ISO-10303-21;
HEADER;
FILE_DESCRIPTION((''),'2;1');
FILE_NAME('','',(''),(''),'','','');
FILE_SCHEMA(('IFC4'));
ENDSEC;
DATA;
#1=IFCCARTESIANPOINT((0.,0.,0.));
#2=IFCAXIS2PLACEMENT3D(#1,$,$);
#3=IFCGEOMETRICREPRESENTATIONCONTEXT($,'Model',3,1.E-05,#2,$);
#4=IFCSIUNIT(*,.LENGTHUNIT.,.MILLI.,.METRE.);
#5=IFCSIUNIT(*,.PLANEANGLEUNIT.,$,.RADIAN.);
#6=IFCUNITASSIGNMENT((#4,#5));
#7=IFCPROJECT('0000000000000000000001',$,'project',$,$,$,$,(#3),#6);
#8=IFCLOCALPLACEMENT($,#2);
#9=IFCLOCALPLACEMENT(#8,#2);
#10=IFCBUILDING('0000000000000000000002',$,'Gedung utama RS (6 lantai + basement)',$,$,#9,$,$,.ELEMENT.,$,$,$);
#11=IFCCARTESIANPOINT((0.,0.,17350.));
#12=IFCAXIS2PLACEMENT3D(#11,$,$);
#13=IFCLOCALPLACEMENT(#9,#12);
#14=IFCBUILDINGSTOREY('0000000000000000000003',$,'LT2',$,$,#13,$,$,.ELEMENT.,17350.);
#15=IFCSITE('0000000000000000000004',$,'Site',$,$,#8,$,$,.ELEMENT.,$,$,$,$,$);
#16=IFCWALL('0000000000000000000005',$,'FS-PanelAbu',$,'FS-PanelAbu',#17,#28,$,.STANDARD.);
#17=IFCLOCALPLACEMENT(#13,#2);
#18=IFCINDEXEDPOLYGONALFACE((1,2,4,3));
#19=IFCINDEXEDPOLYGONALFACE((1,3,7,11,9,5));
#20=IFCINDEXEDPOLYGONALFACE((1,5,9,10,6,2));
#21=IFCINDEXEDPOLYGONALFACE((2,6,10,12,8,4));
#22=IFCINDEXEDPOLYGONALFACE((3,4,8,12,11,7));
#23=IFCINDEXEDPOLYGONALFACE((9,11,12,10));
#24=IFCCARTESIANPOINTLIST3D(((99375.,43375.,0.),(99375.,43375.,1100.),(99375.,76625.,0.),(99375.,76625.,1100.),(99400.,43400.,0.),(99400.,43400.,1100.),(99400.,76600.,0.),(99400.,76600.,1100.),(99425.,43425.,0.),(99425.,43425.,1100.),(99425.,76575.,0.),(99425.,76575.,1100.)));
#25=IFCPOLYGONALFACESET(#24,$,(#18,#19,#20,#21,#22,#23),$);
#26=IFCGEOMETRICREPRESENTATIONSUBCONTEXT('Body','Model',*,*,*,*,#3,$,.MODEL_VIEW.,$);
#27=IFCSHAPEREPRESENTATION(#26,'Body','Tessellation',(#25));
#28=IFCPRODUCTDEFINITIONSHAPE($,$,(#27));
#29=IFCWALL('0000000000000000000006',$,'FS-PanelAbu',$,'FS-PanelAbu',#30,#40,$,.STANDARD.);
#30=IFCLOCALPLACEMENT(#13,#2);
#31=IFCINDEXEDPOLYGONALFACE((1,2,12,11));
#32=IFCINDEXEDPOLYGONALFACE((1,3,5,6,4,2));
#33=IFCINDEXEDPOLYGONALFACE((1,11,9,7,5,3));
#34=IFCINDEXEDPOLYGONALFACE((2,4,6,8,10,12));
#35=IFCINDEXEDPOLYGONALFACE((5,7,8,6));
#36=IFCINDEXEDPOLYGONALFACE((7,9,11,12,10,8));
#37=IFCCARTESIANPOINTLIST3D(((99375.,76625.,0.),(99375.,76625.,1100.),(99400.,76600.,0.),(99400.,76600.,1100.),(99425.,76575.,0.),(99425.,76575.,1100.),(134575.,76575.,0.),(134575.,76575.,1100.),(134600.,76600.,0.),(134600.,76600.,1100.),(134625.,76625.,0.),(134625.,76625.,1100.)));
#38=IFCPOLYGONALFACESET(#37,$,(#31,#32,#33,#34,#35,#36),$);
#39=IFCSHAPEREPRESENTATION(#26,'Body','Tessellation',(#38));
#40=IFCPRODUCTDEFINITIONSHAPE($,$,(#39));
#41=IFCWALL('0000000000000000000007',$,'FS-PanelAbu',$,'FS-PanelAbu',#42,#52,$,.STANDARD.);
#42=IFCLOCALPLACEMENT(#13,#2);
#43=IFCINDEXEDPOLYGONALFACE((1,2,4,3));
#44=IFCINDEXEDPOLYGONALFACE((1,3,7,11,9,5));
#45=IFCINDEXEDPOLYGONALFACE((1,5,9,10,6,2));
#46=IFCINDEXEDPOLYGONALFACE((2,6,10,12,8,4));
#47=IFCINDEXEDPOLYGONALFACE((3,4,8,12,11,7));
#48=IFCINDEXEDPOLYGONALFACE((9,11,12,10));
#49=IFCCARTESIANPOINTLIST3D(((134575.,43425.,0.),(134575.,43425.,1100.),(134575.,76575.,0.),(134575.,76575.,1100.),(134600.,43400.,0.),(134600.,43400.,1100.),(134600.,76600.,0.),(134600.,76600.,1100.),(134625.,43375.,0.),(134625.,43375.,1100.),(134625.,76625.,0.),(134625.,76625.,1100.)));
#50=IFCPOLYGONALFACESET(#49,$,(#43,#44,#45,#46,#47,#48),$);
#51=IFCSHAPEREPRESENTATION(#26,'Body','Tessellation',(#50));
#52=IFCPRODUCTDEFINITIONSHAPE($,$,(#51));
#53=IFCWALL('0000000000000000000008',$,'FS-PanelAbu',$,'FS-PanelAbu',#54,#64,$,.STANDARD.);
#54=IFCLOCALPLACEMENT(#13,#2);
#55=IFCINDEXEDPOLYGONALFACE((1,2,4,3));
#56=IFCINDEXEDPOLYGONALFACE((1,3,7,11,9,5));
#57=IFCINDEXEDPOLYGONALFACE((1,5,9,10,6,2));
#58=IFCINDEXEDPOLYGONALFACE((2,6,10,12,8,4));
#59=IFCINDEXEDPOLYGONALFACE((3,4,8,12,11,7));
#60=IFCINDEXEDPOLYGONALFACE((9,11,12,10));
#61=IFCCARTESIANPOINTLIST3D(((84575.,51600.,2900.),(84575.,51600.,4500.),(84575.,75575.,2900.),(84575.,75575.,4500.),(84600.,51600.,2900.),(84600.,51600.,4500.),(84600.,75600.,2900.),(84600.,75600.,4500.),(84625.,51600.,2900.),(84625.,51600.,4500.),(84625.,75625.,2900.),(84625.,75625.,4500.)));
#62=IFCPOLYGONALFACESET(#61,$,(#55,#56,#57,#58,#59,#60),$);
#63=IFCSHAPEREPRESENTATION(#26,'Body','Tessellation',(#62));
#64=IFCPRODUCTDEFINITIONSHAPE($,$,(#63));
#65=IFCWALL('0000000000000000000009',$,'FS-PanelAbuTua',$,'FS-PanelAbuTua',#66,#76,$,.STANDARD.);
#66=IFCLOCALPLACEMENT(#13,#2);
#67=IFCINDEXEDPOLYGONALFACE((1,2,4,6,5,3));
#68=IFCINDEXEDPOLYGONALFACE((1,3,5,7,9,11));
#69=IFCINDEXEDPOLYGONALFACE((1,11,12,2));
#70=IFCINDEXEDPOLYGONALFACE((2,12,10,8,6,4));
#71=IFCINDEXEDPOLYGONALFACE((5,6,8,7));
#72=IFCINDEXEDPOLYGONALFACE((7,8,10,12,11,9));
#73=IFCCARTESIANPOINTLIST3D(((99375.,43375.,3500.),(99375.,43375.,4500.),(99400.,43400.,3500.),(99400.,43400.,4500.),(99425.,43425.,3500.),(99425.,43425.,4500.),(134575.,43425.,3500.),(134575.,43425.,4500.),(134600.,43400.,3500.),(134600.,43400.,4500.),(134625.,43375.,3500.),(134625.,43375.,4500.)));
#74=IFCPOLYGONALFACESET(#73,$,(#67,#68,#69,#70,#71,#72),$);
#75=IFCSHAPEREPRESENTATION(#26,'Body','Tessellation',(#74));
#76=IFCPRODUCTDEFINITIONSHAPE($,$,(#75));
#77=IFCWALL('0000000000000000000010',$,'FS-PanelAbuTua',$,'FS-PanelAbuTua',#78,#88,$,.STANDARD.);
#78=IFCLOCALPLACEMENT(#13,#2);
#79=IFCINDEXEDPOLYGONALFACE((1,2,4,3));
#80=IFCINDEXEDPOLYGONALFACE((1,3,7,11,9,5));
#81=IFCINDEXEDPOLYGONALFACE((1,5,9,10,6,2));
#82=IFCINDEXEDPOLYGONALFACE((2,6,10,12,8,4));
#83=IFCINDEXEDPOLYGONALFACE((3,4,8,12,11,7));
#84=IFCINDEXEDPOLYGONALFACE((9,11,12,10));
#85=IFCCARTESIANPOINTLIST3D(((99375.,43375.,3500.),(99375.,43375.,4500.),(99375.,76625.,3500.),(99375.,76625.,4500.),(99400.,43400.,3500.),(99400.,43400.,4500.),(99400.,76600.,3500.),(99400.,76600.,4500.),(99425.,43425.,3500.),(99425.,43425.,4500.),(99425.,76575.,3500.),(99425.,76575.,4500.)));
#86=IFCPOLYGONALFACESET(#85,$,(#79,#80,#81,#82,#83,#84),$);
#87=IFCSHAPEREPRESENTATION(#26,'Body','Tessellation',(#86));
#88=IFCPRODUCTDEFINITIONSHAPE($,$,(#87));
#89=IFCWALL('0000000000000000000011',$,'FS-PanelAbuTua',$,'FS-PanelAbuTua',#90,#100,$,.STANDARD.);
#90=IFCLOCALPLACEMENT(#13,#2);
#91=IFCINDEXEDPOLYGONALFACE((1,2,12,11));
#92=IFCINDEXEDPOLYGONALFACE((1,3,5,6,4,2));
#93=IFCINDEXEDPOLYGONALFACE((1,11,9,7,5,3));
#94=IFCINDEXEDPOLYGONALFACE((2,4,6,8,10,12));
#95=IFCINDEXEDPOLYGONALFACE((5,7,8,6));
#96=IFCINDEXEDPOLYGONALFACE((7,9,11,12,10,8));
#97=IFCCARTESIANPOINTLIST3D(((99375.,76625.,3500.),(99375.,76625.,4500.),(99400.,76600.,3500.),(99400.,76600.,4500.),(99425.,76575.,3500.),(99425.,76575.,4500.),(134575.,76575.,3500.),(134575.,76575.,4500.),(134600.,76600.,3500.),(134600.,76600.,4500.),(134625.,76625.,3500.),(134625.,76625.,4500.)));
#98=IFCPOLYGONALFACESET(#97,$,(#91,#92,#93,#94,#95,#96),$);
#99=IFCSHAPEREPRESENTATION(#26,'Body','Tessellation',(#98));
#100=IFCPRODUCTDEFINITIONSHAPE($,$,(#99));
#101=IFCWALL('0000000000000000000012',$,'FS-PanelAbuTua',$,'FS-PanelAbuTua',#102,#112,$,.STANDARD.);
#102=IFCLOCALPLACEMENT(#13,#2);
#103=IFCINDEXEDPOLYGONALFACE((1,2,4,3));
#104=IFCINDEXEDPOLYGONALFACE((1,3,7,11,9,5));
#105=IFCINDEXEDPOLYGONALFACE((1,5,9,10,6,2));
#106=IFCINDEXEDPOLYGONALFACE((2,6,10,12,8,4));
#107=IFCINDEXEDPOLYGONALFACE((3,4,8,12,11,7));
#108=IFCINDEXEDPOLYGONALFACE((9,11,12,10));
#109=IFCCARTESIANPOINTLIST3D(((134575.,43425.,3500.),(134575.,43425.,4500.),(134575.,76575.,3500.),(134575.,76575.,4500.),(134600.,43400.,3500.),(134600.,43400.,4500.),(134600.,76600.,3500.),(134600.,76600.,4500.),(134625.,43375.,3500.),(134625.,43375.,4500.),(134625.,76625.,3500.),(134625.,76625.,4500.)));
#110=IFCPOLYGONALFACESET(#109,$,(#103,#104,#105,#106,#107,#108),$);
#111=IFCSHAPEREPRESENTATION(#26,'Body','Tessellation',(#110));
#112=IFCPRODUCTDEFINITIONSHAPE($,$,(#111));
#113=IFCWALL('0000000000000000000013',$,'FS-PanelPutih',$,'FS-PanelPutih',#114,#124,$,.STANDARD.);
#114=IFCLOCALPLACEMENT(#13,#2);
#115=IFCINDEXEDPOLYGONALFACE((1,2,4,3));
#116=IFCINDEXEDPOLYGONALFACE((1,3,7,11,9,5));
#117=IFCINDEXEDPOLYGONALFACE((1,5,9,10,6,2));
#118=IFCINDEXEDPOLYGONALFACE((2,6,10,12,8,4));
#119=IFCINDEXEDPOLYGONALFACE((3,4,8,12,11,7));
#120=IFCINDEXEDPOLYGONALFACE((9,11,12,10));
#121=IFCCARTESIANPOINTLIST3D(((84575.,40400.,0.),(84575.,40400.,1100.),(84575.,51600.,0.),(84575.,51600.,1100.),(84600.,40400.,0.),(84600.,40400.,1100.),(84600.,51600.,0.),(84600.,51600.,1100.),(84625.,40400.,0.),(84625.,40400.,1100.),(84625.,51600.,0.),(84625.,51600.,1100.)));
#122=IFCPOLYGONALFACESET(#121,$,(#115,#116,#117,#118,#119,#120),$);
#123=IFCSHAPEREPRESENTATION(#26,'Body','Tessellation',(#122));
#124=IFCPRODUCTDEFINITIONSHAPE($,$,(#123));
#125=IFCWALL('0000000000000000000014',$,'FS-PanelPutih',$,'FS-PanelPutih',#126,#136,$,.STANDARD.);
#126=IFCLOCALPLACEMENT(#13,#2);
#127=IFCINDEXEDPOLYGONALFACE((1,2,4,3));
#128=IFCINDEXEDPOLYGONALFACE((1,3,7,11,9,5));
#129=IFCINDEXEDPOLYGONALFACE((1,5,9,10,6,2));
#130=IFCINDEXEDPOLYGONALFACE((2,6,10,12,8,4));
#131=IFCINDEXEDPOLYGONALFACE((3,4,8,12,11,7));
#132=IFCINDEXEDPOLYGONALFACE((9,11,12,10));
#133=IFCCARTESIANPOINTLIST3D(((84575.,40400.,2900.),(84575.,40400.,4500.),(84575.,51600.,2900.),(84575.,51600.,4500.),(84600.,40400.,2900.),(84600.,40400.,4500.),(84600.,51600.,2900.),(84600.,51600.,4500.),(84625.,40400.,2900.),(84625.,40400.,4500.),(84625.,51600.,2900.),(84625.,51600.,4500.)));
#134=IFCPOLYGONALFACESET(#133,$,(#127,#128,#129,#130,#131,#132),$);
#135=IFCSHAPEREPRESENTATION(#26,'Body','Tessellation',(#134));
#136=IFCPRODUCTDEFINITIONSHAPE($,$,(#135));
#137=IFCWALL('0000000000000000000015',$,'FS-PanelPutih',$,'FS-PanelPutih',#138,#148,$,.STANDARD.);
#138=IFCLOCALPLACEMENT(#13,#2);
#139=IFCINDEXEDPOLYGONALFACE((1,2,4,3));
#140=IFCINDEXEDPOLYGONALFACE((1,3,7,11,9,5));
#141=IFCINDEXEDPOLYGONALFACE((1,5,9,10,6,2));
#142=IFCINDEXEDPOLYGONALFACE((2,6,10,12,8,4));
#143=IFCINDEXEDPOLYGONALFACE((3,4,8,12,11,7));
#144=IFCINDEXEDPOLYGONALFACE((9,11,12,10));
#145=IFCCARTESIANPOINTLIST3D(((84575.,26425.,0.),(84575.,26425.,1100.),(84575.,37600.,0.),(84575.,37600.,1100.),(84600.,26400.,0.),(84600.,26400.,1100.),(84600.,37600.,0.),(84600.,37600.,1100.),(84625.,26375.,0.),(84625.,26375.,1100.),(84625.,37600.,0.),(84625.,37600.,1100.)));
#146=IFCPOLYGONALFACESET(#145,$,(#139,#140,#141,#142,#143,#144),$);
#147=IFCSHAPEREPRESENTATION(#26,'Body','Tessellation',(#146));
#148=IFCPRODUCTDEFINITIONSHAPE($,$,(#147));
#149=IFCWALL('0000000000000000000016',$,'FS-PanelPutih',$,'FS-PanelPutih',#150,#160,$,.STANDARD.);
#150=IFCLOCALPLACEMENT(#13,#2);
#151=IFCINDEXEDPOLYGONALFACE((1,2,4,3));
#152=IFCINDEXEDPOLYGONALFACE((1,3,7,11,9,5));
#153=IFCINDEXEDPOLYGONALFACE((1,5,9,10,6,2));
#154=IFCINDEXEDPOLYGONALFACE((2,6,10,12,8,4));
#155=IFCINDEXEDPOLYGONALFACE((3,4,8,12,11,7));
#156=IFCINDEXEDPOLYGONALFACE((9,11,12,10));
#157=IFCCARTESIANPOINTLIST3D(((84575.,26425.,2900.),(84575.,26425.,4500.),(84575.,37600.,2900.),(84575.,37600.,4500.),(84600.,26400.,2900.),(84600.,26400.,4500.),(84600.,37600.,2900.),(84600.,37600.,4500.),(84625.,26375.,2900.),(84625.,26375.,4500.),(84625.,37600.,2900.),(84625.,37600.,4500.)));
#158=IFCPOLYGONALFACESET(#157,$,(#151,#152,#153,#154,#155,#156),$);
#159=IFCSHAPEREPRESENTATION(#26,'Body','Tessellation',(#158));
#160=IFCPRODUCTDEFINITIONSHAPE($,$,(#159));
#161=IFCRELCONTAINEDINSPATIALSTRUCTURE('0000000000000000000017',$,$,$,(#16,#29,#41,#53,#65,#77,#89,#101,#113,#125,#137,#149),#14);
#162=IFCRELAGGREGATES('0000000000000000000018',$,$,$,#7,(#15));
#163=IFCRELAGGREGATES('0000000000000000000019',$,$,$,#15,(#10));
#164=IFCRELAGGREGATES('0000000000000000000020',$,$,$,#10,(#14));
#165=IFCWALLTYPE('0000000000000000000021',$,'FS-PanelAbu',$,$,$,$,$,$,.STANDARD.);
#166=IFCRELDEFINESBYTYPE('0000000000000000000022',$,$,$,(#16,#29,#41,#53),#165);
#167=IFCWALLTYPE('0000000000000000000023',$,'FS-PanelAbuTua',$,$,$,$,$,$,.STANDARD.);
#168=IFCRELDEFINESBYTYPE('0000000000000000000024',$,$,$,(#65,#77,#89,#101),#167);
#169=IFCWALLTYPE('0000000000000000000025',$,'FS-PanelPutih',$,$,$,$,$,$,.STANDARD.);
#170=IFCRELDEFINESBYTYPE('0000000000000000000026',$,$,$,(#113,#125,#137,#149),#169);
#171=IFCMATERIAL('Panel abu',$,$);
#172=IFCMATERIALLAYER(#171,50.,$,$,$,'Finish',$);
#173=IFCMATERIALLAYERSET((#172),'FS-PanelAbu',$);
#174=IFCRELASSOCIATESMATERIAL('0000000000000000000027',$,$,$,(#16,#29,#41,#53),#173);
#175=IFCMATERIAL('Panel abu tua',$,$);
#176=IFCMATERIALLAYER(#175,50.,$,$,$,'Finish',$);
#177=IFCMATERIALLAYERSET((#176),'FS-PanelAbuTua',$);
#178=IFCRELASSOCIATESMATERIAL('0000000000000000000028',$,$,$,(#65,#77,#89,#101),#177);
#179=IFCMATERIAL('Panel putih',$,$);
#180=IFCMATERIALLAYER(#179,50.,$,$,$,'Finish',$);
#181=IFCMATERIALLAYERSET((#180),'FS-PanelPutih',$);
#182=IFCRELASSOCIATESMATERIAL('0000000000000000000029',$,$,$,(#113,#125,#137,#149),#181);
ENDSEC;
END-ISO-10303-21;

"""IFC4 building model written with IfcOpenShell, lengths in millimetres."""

from ifc_helpers import new_model, si_unit, frame, origin, place, context, subcontext, project, spatial, polyline, outline, extrude, material, layer, layer_set, layer_usage, type_object, element, save


model = new_model("IFC4")

# Units and contexts
model_context = context("Model", 3, precision=1e-05, world=origin())
body_context = subcontext(model_context, "Body", "Model", "MODEL_VIEW")
ifc_project = project(units=[si_unit("LENGTHUNIT", "METRE", prefix="MILLI"), si_unit("PLANEANGLEUNIT", "RADIAN")], contexts=[model_context])

# Site, building, storey
site_placement = place(None, origin())
site = spatial("IfcSite", under=ifc_project, at=site_placement, Name="Site", CompositionType="ELEMENT")
building_placement = place(site_placement, origin())
building = spatial("IfcBuilding", under=site, at=building_placement, Name="Gedung utama RS (6 lantai + basement)", CompositionType="ELEMENT")
storey_placement = place(building_placement, frame((0.0, 0.0, 17350.0)))
storey = spatial("IfcBuildingStorey", under=building, at=storey_placement, Name="LT2", CompositionType="ELEMENT", Elevation=17350.0)

# Walls
ifc_material_1 = material(Name="Panel abu")
ifc_layer_1 = layer(ifc_material_1, 50.0, Category="Finish")
ifc_layer_set_1 = layer_set([ifc_layer_1], Name="FS-PanelAbu")
ifc_layer_usage_1 = layer_usage(ifc_layer_set_1, "AXIS2", "NEGATIVE", 25.0)
wall_type_1 = type_object("IfcWallType", Name="FS-PanelAbu", PredefinedType="STANDARD")
wall_1_placement = place(storey_placement, frame((99400.0, 43400.0, 0.0), z_axis=(0.0, 0.0, 1.0), x_axis=(0.0, 1.0, 0.0)))
element("IfcWall", 1, at=wall_1_placement, inside=storey, type_object=wall_type_1, material=ifc_layer_usage_1, Name="FS-PanelAbu", ObjectType="FS-PanelAbu", PredefinedType="STANDARD", context=body_context, shape_type="SweptSolid", body=[
    extrude(outline(polyline([(25.0, -25.0), (0.0, 0.0), (-25.0, 25.0), (33225.0, 25.0), (33200.0, 0.0), (33175.0, -25.0), (25.0, -25.0)])), origin(), (0.0, 0.0, 1.0), 1100.0),
])
wall_2_placement = place(storey_placement, frame((99400.0, 76600.0, 0.0), z_axis=(0.0, 0.0, 1.0), x_axis=(1.0, 0.0, 0.0)))
element("IfcWall", 2, at=wall_2_placement, inside=storey, type_object=wall_type_1, material=ifc_layer_usage_1, Name="FS-PanelAbu", ObjectType="FS-PanelAbu", PredefinedType="STANDARD", context=body_context, shape_type="SweptSolid", body=[
    extrude(outline(polyline([(25.0, -25.0), (0.0, 0.0), (-25.0, 25.0), (35225.0, 25.0), (35200.0, 0.0), (35175.0, -25.0), (25.0, -25.0)])), origin(), (0.0, 0.0, 1.0), 1100.0),
])
wall_3_placement = place(storey_placement, frame((134600.0, 76600.0, 0.0), z_axis=(0.0, 0.0, 1.0), x_axis=(0.0, -1.0, 0.0)))
element("IfcWall", 3, at=wall_3_placement, inside=storey, type_object=wall_type_1, material=ifc_layer_usage_1, Name="FS-PanelAbu", ObjectType="FS-PanelAbu", PredefinedType="STANDARD", context=body_context, shape_type="SweptSolid", body=[
    extrude(outline(polyline([(25.0, -25.0), (0.0, 0.0), (-25.0, 25.0), (33225.0, 25.0), (33200.0, 0.0), (33175.0, -25.0), (25.0, -25.0)])), origin(), (0.0, 0.0, 1.0), 1100.0),
])
wall_4_placement = place(storey_placement, frame((84600.0, 75600.0, 2900.0), z_axis=(0.0, 0.0, 1.0), x_axis=(0.0, -1.0, 0.0)))
element("IfcWall", 4, at=wall_4_placement, inside=storey, type_object=wall_type_1, material=ifc_layer_usage_1, Name="FS-PanelAbu", ObjectType="FS-PanelAbu", PredefinedType="STANDARD", context=body_context, shape_type="SweptSolid", body=[
    extrude(outline(polyline([(25.0, -25.0), (0.0, 0.0), (-25.0, 25.0), (24000.0, 25.0), (24000.0, 0.0), (24000.0, -25.0), (25.0, -25.0)])), origin(), (0.0, 0.0, 1.0), 1600.0),
])
ifc_material_2 = material(Name="Panel abu tua")
ifc_layer_2 = layer(ifc_material_2, 50.0, Category="Finish")
ifc_layer_set_2 = layer_set([ifc_layer_2], Name="FS-PanelAbuTua")
ifc_layer_usage_2 = layer_usage(ifc_layer_set_2, "AXIS2", "NEGATIVE", 25.0)
wall_type_2 = type_object("IfcWallType", Name="FS-PanelAbuTua", PredefinedType="STANDARD")
wall_5_placement = place(storey_placement, frame((134600.0, 43400.0, 3500.0), z_axis=(0.0, 0.0, 1.0), x_axis=(-1.0, 0.0, 0.0)))
element("IfcWall", 5, at=wall_5_placement, inside=storey, type_object=wall_type_2, material=ifc_layer_usage_2, Name="FS-PanelAbuTua", ObjectType="FS-PanelAbuTua", PredefinedType="STANDARD", context=body_context, shape_type="SweptSolid", body=[
    extrude(outline(polyline([(25.0, -25.0), (0.0, 0.0), (-25.0, 25.0), (35225.0, 25.0), (35200.0, 0.0), (35175.0, -25.0), (25.0, -25.0)])), origin(), (0.0, 0.0, 1.0), 1000.0),
])
wall_6_placement = place(storey_placement, frame((99400.0, 43400.0, 3500.0), z_axis=(0.0, 0.0, 1.0), x_axis=(0.0, 1.0, 0.0)))
element("IfcWall", 6, at=wall_6_placement, inside=storey, type_object=wall_type_2, material=ifc_layer_usage_2, Name="FS-PanelAbuTua", ObjectType="FS-PanelAbuTua", PredefinedType="STANDARD", context=body_context, shape_type="SweptSolid", body=[
    extrude(outline(polyline([(25.0, -25.0), (0.0, 0.0), (-25.0, 25.0), (33225.0, 25.0), (33200.0, 0.0), (33175.0, -25.0), (25.0, -25.0)])), origin(), (0.0, 0.0, 1.0), 1000.0),
])
wall_7_placement = place(storey_placement, frame((99400.0, 76600.0, 3500.0), z_axis=(0.0, 0.0, 1.0), x_axis=(1.0, 0.0, 0.0)))
element("IfcWall", 7, at=wall_7_placement, inside=storey, type_object=wall_type_2, material=ifc_layer_usage_2, Name="FS-PanelAbuTua", ObjectType="FS-PanelAbuTua", PredefinedType="STANDARD", context=body_context, shape_type="SweptSolid", body=[
    extrude(outline(polyline([(25.0, -25.0), (0.0, 0.0), (-25.0, 25.0), (35225.0, 25.0), (35200.0, 0.0), (35175.0, -25.0), (25.0, -25.0)])), origin(), (0.0, 0.0, 1.0), 1000.0),
])
wall_8_placement = place(storey_placement, frame((134600.0, 76600.0, 3500.0), z_axis=(0.0, 0.0, 1.0), x_axis=(0.0, -1.0, 0.0)))
element("IfcWall", 8, at=wall_8_placement, inside=storey, type_object=wall_type_2, material=ifc_layer_usage_2, Name="FS-PanelAbuTua", ObjectType="FS-PanelAbuTua", PredefinedType="STANDARD", context=body_context, shape_type="SweptSolid", body=[
    extrude(outline(polyline([(25.0, -25.0), (0.0, 0.0), (-25.0, 25.0), (33225.0, 25.0), (33200.0, 0.0), (33175.0, -25.0), (25.0, -25.0)])), origin(), (0.0, 0.0, 1.0), 1000.0),
])
ifc_material_3 = material(Name="Panel putih")
ifc_layer_3 = layer(ifc_material_3, 50.0, Category="Finish")
ifc_layer_set_3 = layer_set([ifc_layer_3], Name="FS-PanelPutih")
ifc_layer_usage_3 = layer_usage(ifc_layer_set_3, "AXIS2", "NEGATIVE", 25.0)
wall_type_3 = type_object("IfcWallType", Name="FS-PanelPutih", PredefinedType="STANDARD")
wall_9_placement = place(storey_placement, frame((84600.0, 51600.0, 0.0), z_axis=(0.0, 0.0, 1.0), x_axis=(0.0, -1.0, 0.0)))
element("IfcWall", 9, at=wall_9_placement, inside=storey, type_object=wall_type_3, material=ifc_layer_usage_3, Name="FS-PanelPutih", ObjectType="FS-PanelPutih", PredefinedType="STANDARD", context=body_context, shape_type="SweptSolid", body=[
    extrude(outline(polyline([(0.0, -25.0), (0.0, 0.0), (0.0, 25.0), (11200.0, 25.0), (11200.0, 0.0), (11200.0, -25.0), (0.0, -25.0)])), origin(), (0.0, 0.0, 1.0), 1100.0),
])
wall_10_placement = place(storey_placement, frame((84600.0, 51600.0, 2900.0), z_axis=(0.0, 0.0, 1.0), x_axis=(0.0, -1.0, 0.0)))
element("IfcWall", 10, at=wall_10_placement, inside=storey, type_object=wall_type_3, material=ifc_layer_usage_3, Name="FS-PanelPutih", ObjectType="FS-PanelPutih", PredefinedType="STANDARD", context=body_context, shape_type="SweptSolid", body=[
    extrude(outline(polyline([(0.0, -25.0), (0.0, 0.0), (0.0, 25.0), (11200.0, 25.0), (11200.0, 0.0), (11200.0, -25.0), (0.0, -25.0)])), origin(), (0.0, 0.0, 1.0), 1600.0),
])
wall_11_placement = place(storey_placement, frame((84600.0, 37600.0, 0.0), z_axis=(0.0, 0.0, 1.0), x_axis=(0.0, -1.0, 0.0)))
element("IfcWall", 11, at=wall_11_placement, inside=storey, type_object=wall_type_3, material=ifc_layer_usage_3, Name="FS-PanelPutih", ObjectType="FS-PanelPutih", PredefinedType="STANDARD", context=body_context, shape_type="SweptSolid", body=[
    extrude(outline(polyline([(0.0, -25.0), (0.0, 0.0), (0.0, 25.0), (11225.0, 25.0), (11200.0, 0.0), (11175.0, -25.0), (0.0, -25.0)])), origin(), (0.0, 0.0, 1.0), 1100.0),
])
wall_12_placement = place(storey_placement, frame((84600.0, 37600.0, 2900.0), z_axis=(0.0, 0.0, 1.0), x_axis=(0.0, -1.0, 0.0)))
element("IfcWall", 12, at=wall_12_placement, inside=storey, type_object=wall_type_3, material=ifc_layer_usage_3, Name="FS-PanelPutih", ObjectType="FS-PanelPutih", PredefinedType="STANDARD", context=body_context, shape_type="SweptSolid", body=[
    extrude(outline(polyline([(0.0, -25.0), (0.0, 0.0), (0.0, 25.0), (11225.0, 25.0), (11200.0, 0.0), (11175.0, -25.0), (0.0, -25.0)])), origin(), (0.0, 0.0, 1.0), 1600.0),
])

save(model, "model.ifc")
